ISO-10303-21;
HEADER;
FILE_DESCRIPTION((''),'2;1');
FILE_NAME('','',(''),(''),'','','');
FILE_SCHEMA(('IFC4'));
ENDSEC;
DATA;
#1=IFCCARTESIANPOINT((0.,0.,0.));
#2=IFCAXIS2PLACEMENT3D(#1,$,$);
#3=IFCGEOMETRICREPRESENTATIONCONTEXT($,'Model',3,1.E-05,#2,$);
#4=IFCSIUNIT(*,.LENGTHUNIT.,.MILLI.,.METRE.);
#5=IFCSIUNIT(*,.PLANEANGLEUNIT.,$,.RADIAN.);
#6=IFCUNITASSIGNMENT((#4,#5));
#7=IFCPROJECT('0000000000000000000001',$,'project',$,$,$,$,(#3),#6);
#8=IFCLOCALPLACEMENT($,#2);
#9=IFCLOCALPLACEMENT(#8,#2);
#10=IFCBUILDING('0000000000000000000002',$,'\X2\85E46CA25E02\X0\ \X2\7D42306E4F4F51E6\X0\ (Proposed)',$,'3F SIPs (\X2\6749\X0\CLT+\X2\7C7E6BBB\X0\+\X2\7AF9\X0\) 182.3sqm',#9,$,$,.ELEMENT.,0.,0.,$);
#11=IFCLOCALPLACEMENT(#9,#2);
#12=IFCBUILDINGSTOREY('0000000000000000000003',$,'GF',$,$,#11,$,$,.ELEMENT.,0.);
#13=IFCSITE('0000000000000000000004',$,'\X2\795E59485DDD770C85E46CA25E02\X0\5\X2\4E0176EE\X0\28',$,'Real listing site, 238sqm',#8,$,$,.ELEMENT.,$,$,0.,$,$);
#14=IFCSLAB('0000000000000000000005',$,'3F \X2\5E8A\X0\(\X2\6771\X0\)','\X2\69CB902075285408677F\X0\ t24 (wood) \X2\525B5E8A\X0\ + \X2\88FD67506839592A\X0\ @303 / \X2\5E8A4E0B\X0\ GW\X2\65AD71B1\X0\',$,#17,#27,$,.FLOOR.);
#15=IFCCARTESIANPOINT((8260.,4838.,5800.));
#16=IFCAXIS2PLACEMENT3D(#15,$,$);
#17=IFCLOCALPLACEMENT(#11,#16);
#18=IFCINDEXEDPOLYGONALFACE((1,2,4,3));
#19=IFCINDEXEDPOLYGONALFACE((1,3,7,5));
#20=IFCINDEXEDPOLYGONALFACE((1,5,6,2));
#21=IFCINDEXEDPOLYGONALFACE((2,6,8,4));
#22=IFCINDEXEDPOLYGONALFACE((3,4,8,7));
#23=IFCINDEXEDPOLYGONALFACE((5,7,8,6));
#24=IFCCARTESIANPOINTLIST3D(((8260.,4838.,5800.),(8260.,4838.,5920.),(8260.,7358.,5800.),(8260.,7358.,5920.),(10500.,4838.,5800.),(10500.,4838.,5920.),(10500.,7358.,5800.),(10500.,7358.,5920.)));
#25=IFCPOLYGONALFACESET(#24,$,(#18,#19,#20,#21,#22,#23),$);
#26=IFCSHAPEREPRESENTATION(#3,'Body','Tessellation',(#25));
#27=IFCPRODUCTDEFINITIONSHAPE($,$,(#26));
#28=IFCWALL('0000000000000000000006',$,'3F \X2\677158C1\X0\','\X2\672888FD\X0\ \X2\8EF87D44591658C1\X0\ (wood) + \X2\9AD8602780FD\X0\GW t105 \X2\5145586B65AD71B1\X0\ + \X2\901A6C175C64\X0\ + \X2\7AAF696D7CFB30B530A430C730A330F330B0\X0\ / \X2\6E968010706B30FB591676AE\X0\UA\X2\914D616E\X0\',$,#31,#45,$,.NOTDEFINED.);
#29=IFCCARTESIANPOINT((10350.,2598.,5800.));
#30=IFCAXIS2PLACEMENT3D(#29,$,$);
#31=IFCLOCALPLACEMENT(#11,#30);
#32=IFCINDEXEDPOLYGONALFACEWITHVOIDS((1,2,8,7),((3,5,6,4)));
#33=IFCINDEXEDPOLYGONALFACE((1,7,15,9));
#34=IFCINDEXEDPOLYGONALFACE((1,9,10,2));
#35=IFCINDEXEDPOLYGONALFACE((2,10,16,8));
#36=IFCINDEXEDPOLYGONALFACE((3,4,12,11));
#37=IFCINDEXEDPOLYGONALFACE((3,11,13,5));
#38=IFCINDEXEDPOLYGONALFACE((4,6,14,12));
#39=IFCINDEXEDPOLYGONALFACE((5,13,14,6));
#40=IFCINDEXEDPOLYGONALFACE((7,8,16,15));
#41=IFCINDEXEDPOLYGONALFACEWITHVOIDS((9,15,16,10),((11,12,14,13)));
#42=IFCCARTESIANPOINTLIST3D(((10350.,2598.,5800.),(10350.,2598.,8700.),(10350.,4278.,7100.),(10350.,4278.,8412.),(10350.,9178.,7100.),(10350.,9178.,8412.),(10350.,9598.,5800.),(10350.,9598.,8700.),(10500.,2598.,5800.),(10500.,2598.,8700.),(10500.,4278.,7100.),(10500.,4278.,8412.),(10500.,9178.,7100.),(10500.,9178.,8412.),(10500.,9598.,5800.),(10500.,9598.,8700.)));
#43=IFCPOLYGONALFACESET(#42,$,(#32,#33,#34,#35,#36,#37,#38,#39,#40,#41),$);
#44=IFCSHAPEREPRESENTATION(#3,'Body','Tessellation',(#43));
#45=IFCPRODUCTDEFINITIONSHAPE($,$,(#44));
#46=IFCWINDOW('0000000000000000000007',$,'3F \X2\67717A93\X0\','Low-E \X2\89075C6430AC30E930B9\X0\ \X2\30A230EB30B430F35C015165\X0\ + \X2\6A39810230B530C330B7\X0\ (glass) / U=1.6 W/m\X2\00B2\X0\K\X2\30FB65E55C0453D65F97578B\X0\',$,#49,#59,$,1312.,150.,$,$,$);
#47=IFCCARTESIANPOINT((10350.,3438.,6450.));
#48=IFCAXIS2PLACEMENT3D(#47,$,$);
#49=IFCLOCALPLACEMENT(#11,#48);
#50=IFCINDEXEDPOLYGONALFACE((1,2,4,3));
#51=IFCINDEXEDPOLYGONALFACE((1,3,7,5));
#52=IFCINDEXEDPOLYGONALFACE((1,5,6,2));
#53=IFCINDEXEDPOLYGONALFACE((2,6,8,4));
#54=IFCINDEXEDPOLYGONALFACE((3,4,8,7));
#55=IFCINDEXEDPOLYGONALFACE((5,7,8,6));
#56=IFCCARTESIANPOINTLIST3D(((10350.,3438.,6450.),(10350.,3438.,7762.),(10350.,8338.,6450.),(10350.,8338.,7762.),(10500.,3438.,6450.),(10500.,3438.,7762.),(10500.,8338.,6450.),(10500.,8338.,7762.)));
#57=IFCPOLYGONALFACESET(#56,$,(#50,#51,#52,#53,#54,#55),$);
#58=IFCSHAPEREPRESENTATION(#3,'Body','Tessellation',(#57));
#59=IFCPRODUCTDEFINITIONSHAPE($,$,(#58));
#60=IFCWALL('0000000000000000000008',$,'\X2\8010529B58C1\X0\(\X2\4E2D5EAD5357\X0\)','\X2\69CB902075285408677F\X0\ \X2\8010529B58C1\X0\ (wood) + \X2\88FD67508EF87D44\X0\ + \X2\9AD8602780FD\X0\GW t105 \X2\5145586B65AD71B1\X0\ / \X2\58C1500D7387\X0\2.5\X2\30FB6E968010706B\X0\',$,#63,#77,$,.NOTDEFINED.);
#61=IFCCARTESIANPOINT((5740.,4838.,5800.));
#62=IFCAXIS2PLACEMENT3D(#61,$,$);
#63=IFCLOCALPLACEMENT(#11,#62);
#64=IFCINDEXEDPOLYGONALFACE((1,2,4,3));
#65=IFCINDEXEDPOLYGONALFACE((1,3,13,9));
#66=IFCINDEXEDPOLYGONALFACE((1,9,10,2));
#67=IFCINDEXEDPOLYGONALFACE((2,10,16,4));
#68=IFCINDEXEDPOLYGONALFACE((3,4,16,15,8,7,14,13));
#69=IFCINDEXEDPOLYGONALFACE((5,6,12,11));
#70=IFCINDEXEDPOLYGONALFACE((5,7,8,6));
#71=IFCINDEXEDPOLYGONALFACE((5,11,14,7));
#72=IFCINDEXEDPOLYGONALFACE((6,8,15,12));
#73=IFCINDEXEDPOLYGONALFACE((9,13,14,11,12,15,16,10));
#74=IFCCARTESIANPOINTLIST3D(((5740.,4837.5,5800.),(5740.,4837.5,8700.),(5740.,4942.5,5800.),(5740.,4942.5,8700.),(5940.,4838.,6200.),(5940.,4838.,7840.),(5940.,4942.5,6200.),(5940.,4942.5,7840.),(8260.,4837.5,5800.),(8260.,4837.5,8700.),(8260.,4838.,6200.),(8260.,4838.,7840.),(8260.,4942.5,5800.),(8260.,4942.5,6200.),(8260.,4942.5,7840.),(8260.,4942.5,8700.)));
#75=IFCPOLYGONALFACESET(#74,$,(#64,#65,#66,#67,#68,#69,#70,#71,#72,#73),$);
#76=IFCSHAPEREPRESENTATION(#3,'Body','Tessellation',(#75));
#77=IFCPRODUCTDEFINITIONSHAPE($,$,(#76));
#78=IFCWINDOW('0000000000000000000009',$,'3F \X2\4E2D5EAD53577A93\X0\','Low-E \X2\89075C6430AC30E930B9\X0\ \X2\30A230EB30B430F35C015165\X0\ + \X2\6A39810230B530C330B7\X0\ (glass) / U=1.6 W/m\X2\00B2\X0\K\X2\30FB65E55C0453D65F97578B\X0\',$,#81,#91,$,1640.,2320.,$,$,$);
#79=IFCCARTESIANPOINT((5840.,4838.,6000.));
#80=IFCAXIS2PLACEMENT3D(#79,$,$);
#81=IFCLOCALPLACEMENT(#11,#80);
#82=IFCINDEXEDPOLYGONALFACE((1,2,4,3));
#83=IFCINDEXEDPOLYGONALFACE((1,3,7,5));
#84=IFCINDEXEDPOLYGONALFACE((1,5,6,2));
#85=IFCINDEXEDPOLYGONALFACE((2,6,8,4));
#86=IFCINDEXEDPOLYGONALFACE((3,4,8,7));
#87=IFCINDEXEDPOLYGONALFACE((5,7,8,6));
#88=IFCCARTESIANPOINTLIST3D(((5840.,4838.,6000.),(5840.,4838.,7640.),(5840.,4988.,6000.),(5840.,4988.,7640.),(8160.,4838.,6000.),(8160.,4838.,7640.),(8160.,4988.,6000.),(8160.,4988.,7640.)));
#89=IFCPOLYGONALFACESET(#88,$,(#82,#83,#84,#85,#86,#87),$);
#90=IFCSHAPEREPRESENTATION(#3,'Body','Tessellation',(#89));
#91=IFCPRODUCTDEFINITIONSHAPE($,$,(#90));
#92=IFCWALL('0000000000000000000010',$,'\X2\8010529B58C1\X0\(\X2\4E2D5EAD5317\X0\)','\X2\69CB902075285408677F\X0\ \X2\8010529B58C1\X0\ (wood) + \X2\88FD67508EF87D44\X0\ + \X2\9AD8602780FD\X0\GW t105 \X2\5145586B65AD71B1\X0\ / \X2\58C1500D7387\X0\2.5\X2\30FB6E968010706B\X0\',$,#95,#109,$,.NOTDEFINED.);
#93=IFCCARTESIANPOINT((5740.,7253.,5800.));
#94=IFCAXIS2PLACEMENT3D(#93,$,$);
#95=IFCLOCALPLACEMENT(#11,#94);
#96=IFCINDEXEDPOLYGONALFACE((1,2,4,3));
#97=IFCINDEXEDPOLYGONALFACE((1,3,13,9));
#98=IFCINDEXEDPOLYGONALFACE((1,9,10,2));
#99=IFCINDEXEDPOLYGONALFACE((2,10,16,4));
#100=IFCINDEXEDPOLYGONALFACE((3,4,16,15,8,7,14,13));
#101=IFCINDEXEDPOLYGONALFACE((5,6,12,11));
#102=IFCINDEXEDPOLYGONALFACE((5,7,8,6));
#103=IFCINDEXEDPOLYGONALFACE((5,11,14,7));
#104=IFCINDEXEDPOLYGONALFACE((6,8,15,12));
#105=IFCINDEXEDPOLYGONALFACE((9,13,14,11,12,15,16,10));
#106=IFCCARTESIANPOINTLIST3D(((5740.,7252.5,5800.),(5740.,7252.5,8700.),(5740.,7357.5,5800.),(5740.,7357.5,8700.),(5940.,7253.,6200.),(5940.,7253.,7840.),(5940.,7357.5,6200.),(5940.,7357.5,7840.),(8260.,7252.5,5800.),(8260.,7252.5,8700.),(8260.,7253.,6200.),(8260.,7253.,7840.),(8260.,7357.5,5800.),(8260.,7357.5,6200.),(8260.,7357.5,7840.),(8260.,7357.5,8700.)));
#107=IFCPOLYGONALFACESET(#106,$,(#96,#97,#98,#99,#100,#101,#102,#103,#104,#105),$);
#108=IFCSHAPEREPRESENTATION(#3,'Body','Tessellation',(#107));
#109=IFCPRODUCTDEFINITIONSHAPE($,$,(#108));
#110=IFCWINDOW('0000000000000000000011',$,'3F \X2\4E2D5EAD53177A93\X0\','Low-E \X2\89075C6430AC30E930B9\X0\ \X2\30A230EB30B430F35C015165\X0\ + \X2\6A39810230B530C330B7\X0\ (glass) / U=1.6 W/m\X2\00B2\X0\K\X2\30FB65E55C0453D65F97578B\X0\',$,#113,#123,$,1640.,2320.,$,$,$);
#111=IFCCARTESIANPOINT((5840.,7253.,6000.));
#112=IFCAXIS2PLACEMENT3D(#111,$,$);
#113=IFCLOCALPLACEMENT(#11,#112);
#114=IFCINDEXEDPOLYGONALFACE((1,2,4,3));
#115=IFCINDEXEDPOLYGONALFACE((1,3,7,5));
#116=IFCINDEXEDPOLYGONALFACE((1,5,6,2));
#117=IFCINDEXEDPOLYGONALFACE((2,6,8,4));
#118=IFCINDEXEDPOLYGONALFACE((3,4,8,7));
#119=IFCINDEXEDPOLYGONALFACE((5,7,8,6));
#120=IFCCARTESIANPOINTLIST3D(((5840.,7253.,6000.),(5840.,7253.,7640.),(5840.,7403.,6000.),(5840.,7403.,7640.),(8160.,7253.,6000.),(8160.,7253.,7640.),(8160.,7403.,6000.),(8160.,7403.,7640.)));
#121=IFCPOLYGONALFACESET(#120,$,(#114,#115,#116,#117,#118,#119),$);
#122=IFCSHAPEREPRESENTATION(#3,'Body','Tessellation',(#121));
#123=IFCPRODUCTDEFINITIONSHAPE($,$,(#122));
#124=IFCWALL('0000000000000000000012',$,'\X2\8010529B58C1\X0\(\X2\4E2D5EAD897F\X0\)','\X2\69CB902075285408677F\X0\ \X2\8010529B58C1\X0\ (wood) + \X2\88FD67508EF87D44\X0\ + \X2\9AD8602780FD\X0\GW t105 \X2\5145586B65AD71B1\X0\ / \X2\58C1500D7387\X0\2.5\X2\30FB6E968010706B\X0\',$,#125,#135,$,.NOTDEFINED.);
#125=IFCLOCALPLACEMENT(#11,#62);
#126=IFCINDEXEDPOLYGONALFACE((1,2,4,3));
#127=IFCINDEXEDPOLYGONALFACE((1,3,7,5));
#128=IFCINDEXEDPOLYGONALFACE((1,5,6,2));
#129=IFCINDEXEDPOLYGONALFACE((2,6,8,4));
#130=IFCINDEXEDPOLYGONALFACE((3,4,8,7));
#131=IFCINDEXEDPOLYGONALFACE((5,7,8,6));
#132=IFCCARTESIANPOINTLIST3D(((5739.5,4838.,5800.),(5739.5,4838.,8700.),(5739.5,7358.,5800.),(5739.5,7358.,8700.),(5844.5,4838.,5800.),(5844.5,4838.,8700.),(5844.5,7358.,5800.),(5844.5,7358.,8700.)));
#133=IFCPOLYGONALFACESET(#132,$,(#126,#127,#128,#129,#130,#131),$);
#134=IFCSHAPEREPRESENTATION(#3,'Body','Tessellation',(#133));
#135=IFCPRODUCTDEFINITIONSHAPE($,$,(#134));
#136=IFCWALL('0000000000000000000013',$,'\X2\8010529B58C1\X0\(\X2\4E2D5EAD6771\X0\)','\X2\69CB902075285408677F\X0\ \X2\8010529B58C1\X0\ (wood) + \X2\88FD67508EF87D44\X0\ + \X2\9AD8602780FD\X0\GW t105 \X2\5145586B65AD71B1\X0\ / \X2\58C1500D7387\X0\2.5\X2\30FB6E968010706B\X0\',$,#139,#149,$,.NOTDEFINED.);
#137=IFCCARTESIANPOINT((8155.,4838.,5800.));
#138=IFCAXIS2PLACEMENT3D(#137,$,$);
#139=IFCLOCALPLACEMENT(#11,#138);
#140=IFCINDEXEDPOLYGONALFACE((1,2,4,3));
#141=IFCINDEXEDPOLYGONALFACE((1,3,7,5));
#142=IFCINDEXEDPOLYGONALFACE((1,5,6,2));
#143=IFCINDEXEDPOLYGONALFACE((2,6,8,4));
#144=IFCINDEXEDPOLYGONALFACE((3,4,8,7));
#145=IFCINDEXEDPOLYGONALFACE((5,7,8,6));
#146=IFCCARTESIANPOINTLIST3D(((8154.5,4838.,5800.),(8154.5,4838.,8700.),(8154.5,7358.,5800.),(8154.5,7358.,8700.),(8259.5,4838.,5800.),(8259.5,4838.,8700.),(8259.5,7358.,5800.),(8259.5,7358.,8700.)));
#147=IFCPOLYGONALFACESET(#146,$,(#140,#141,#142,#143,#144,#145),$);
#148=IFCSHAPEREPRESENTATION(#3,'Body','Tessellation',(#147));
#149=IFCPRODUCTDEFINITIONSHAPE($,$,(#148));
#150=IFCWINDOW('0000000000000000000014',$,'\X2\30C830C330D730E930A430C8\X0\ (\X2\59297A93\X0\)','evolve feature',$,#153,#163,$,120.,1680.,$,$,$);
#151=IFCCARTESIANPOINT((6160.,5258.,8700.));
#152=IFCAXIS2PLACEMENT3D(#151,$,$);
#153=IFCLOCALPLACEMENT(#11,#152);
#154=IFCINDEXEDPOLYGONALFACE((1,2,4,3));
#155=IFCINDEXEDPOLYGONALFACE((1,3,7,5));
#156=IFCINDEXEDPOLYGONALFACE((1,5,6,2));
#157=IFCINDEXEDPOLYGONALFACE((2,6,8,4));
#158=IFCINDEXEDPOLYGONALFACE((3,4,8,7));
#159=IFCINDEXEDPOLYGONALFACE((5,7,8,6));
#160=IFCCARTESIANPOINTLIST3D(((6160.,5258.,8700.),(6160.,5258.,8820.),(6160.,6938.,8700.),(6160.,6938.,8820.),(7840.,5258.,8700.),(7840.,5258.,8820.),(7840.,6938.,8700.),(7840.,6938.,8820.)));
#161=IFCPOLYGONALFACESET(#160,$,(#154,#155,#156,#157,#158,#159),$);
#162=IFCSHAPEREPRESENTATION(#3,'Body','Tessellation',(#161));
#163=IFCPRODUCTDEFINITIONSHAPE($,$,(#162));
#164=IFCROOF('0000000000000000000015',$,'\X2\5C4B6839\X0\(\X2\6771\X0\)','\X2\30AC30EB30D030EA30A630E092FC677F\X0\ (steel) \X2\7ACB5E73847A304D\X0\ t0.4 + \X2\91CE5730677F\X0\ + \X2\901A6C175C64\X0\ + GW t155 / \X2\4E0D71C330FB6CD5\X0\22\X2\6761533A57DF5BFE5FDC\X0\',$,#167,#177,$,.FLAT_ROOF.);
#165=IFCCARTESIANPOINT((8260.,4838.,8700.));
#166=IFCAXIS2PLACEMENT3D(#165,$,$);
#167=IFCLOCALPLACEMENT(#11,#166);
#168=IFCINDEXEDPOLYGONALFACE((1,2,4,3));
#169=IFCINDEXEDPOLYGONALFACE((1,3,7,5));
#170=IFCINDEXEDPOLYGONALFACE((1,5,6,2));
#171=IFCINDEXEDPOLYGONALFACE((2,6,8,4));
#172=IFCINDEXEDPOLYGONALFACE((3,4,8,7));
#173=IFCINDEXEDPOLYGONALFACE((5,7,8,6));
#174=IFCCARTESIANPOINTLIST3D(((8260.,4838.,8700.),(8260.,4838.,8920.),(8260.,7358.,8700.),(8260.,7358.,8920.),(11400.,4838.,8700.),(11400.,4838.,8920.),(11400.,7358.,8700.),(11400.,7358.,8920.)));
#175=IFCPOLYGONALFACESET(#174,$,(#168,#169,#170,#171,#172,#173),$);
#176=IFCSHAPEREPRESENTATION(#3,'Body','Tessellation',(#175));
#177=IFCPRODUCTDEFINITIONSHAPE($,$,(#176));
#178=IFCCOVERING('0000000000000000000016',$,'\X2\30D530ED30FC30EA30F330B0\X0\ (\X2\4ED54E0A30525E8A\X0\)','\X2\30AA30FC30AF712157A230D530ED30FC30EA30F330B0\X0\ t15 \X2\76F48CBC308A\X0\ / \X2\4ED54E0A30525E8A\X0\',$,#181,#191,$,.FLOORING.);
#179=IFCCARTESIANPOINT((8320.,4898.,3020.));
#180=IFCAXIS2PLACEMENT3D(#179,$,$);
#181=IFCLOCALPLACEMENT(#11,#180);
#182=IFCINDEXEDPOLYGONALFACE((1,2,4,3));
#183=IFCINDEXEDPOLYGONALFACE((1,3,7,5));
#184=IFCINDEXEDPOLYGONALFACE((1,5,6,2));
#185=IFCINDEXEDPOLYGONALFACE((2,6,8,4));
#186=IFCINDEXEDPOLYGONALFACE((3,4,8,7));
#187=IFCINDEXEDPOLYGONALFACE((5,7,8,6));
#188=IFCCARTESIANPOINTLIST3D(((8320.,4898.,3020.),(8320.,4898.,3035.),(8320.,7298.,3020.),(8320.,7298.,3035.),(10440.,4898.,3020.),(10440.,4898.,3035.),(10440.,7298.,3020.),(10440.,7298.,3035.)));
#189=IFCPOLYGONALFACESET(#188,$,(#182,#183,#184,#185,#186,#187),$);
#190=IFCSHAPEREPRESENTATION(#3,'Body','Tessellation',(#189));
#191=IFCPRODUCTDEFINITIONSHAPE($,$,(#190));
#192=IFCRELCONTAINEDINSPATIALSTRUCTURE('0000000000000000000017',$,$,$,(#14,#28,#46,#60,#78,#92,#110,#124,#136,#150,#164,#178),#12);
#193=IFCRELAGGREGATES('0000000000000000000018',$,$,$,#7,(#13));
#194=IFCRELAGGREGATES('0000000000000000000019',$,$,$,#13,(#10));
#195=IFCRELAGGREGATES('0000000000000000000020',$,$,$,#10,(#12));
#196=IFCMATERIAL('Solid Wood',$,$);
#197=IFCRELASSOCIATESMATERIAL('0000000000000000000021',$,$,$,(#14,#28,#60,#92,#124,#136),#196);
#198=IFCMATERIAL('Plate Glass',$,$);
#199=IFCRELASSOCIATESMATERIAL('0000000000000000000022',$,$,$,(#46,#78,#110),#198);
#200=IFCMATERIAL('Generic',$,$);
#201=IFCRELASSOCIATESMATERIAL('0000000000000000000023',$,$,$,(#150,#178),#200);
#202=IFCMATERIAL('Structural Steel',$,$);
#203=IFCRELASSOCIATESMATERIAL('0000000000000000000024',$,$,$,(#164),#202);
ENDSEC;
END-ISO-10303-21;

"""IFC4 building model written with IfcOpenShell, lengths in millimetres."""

from ifc_helpers import new_model, si_unit, frame, frame_2d, origin, place, context, project, spatial, rectangle, extrude, material, element, fill, save


model = new_model("IFC4")

# Units and contexts
model_context = context("Model", 3, precision=1e-05, world=origin())
ifc_project = project(units=[si_unit("LENGTHUNIT", "METRE", prefix="MILLI"), si_unit("PLANEANGLEUNIT", "RADIAN")], contexts=[model_context])

# Site, building, storey
site_placement = place(None, origin())
site = spatial("IfcSite", under=ifc_project, at=site_placement, Name="神奈川県藤沢市5丁目28", ObjectType="Real listing site, 238sqm", CompositionType="ELEMENT", RefElevation=0.0)
building_placement = place(site_placement, origin())
building = spatial("IfcBuilding", under=site, at=building_placement, Name="藤沢市 終の住処 (Proposed)", ObjectType="3F SIPs (杉CLT+籾殻+竹) 182.3sqm", CompositionType="ELEMENT", ElevationOfRefHeight=0.0, ElevationOfTerrain=0.0)
storey_placement = place(building_placement, origin())
storey = spatial("IfcBuildingStorey", under=building, at=storey_placement, Name="GF", CompositionType="ELEMENT", Elevation=0.0)

# Slab
ifc_material_1 = material(Name="Solid Wood")
slab_placement = place(storey_placement, frame((8260.0, 4838.0, 5800.0)))
element("IfcSlab", 1, at=slab_placement, inside=storey, material=ifc_material_1, Name="3F 床(東)", Description="構造用合板 t24 (wood) 剛床 + 製材根太 @303 / 床下 GW断熱", PredefinedType="FLOOR", context=model_context, shape_type="SweptSolid", body=[
    extrude(rectangle(XDim=2240.0, YDim=2520.0, at=frame_2d((1120.0, 1260.0))), frame((8260.0, 4838.0, 5800.0)), (0.0, 0.0, 1.0), 120.0),
])

# Walls, openings, windows
wall_1_placement = place(storey_placement, frame((10350.0, 2598.0, 5800.0)))
wall_1 = element("IfcWall", 2, at=wall_1_placement, inside=storey, material=ifc_material_1, Name="3F 東壁", Description="木製 軸組外壁 (wood) + 高性能GW t105 充填断熱 + 通気層 + 窯業系サイディング / 準耐火・外皮UA配慮", PredefinedType="NOTDEFINED", context=model_context, shape_type="SweptSolid", body=[
    extrude(rectangle(XDim=150.0, YDim=7000.0, at=frame_2d((75.0, 3500.0))), frame((10350.0, 2598.0, 5800.0)), (0.0, 0.0, 1.0), 2900.0),
])
opening_1_placement = place(storey_placement, frame((10350.0, 3438.0, 6450.0)))
opening_1 = element("IfcOpeningElement", 3, at=opening_1_placement, cuts=wall_1, PredefinedType="NOTDEFINED", context=model_context, shape_type="SweptSolid", body=[
    extrude(rectangle(XDim=150.0, YDim=4900.0, at=frame_2d((75.0, 2450.0))), frame((10350.0, 3438.0, 6450.0)), (0.0, 0.0, 1.0), 1312.0),
])
ifc_material_2 = material(Name="Plate Glass")
window_1_placement = place(storey_placement, frame((10350.0, 3438.0, 6450.0)))
window_1 = element("IfcWindow", 4, at=window_1_placement, inside=storey, material=ifc_material_2, Name="3F 東窓", Description="Low-E 複層ガラス アルゴン封入 + 樹脂サッシ (glass) / U=1.6 W/m²K・日射取得型", OverallHeight=1312.0, OverallWidth=150.0, context=model_context, shape_type="SweptSolid", body=[
    extrude(rectangle(XDim=150.0, YDim=4900.0, at=frame_2d((75.0, 2450.0))), frame((10350.0, 3438.0, 6450.0)), (0.0, 0.0, 1.0), 1312.0),
])
fill(opening_1, window_1)
wall_2_placement = place(storey_placement, frame((5740.0, 4838.0, 5800.0)))
wall_2 = element("IfcWall", 5, at=wall_2_placement, inside=storey, material=ifc_material_1, Name="耐力壁(中庭南)", Description="構造用合板 耐力壁 (wood) + 製材軸組 + 高性能GW t105 充填断熱 / 壁倍率2.5・準耐火", PredefinedType="NOTDEFINED", context=model_context, shape_type="SweptSolid", body=[
    extrude(rectangle(XDim=2520.0, YDim=105.0, at=frame_2d((1260.0, 52.0))), frame((5740.0, 4838.0, 5800.0)), (0.0, 0.0, 1.0), 2900.0),
])
opening_2_placement = place(storey_placement, frame((5840.0, 4838.0, 6000.0)))
opening_2 = element("IfcOpeningElement", 6, at=opening_2_placement, cuts=wall_2, PredefinedType="NOTDEFINED", context=model_context, shape_type="SweptSolid", body=[
    extrude(rectangle(XDim=2320.0, YDim=150.0, at=frame_2d((1160.0, 75.0))), frame((5840.0, 4838.0, 6000.0)), (0.0, 0.0, 1.0), 1640.0),
])
window_2_placement = place(storey_placement, frame((5840.0, 4838.0, 6000.0)))
window_2 = element("IfcWindow", 7, at=window_2_placement, inside=storey, material=ifc_material_2, Name="3F 中庭南窓", Description="Low-E 複層ガラス アルゴン封入 + 樹脂サッシ (glass) / U=1.6 W/m²K・日射取得型", OverallHeight=1640.0, OverallWidth=2320.0, context=model_context, shape_type="SweptSolid", body=[
    extrude(rectangle(XDim=2320.0, YDim=150.0, at=frame_2d((1160.0, 75.0))), frame((5840.0, 4838.0, 6000.0)), (0.0, 0.0, 1.0), 1640.0),
])
fill(opening_2, window_2)
wall_3_placement = place(storey_placement, frame((5740.0, 7253.0, 5800.0)))
wall_3 = element("IfcWall", 8, at=wall_3_placement, inside=storey, material=ifc_material_1, Name="耐力壁(中庭北)", Description="構造用合板 耐力壁 (wood) + 製材軸組 + 高性能GW t105 充填断熱 / 壁倍率2.5・準耐火", PredefinedType="NOTDEFINED", context=model_context, shape_type="SweptSolid", body=[
    extrude(rectangle(XDim=2520.0, YDim=105.0, at=frame_2d((1260.0, 52.0))), frame((5740.0, 7253.0, 5800.0)), (0.0, 0.0, 1.0), 2900.0),
])
opening_3_placement = place(storey_placement, frame((5840.0, 7253.0, 6000.0)))
opening_3 = element("IfcOpeningElement", 9, at=opening_3_placement, cuts=wall_3, PredefinedType="NOTDEFINED", context=model_context, shape_type="SweptSolid", body=[
    extrude(rectangle(XDim=2320.0, YDim=150.0, at=frame_2d((1160.0, 75.0))), frame((5840.0, 7253.0, 6000.0)), (0.0, 0.0, 1.0), 1640.0),
])
window_3_placement = place(storey_placement, frame((5840.0, 7253.0, 6000.0)))
window_3 = element("IfcWindow", 10, at=window_3_placement, inside=storey, material=ifc_material_2, Name="3F 中庭北窓", Description="Low-E 複層ガラス アルゴン封入 + 樹脂サッシ (glass) / U=1.6 W/m²K・日射取得型", OverallHeight=1640.0, OverallWidth=2320.0, context=model_context, shape_type="SweptSolid", body=[
    extrude(rectangle(XDim=2320.0, YDim=150.0, at=frame_2d((1160.0, 75.0))), frame((5840.0, 7253.0, 6000.0)), (0.0, 0.0, 1.0), 1640.0),
])
fill(opening_3, window_3)

# Walls
wall_4_placement = place(storey_placement, frame((5740.0, 4838.0, 5800.0)))
element("IfcWall", 11, at=wall_4_placement, inside=storey, material=ifc_material_1, Name="耐力壁(中庭西)", Description="構造用合板 耐力壁 (wood) + 製材軸組 + 高性能GW t105 充填断熱 / 壁倍率2.5・準耐火", PredefinedType="NOTDEFINED", context=model_context, shape_type="SweptSolid", body=[
    extrude(rectangle(XDim=105.0, YDim=2520.0, at=frame_2d((52.0, 1260.0))), frame((5740.0, 4838.0, 5800.0)), (0.0, 0.0, 1.0), 2900.0),
])
wall_5_placement = place(storey_placement, frame((8155.0, 4838.0, 5800.0)))
element("IfcWall", 12, at=wall_5_placement, inside=storey, material=ifc_material_1, Name="耐力壁(中庭東)", Description="構造用合板 耐力壁 (wood) + 製材軸組 + 高性能GW t105 充填断熱 / 壁倍率2.5・準耐火", PredefinedType="NOTDEFINED", context=model_context, shape_type="SweptSolid", body=[
    extrude(rectangle(XDim=105.0, YDim=2520.0, at=frame_2d((52.0, 1260.0))), frame((8155.0, 4838.0, 5800.0)), (0.0, 0.0, 1.0), 2900.0),
])

# Window
ifc_material_3 = material(Name="Generic")
window_4_placement = place(storey_placement, frame((6160.0, 5258.0, 8700.0)))
element("IfcWindow", 13, at=window_4_placement, inside=storey, material=ifc_material_3, Name="トップライト (天窓)", Description="evolve feature", OverallHeight=120.0, OverallWidth=1680.0, context=model_context, shape_type="SweptSolid", body=[
    extrude(rectangle(XDim=1680.0, YDim=1680.0, at=frame_2d((840.0, 840.0))), frame((6160.0, 5258.0, 8700.0)), (0.0, 0.0, 1.0), 120.0),
])

# Roof
ifc_material_4 = material(Name="Structural Steel")
for number, where, name in (
    (14, (8260.0, 4838.0, 8700.0), "屋根(東)"),
):
    element("IfcRoof", number, at=place(storey_placement, frame(where)), inside=storey, material=ifc_material_4, Name=name, Description="ガルバリウム鋼板 (steel) 立平葺き t0.4 + 野地板 + 通気層 + GW t155 / 不燃・法22条区域対応", PredefinedType="FLAT_ROOF", context=model_context, shape_type="SweptSolid", body=[
        extrude(rectangle(XDim=3140.0, YDim=2520.0, at=frame_2d((1570.0, 1260.0))), frame((8260.0, 4838.0, 8700.0)), (0.0, 0.0, 1.0), 220.0),
    ])

# Covering
covering_1_placement = place(storey_placement, frame((8320.0, 4898.0, 3020.0)))
element("IfcCovering", 15, at=covering_1_placement, inside=storey, material=ifc_material_3, Name="フローリング (仕上げ床)", Description="オーク無垢フローリング t15 直貼り / 仕上げ床", PredefinedType="FLOORING", context=model_context, shape_type="SweptSolid", body=[
    extrude(rectangle(XDim=2120.0, YDim=2400.0, at=frame_2d((1060.0, 1200.0))), frame((8320.0, 4898.0, 3020.0)), (0.0, 0.0, 1.0), 15.0),
])

save(model, "model.ifc")
